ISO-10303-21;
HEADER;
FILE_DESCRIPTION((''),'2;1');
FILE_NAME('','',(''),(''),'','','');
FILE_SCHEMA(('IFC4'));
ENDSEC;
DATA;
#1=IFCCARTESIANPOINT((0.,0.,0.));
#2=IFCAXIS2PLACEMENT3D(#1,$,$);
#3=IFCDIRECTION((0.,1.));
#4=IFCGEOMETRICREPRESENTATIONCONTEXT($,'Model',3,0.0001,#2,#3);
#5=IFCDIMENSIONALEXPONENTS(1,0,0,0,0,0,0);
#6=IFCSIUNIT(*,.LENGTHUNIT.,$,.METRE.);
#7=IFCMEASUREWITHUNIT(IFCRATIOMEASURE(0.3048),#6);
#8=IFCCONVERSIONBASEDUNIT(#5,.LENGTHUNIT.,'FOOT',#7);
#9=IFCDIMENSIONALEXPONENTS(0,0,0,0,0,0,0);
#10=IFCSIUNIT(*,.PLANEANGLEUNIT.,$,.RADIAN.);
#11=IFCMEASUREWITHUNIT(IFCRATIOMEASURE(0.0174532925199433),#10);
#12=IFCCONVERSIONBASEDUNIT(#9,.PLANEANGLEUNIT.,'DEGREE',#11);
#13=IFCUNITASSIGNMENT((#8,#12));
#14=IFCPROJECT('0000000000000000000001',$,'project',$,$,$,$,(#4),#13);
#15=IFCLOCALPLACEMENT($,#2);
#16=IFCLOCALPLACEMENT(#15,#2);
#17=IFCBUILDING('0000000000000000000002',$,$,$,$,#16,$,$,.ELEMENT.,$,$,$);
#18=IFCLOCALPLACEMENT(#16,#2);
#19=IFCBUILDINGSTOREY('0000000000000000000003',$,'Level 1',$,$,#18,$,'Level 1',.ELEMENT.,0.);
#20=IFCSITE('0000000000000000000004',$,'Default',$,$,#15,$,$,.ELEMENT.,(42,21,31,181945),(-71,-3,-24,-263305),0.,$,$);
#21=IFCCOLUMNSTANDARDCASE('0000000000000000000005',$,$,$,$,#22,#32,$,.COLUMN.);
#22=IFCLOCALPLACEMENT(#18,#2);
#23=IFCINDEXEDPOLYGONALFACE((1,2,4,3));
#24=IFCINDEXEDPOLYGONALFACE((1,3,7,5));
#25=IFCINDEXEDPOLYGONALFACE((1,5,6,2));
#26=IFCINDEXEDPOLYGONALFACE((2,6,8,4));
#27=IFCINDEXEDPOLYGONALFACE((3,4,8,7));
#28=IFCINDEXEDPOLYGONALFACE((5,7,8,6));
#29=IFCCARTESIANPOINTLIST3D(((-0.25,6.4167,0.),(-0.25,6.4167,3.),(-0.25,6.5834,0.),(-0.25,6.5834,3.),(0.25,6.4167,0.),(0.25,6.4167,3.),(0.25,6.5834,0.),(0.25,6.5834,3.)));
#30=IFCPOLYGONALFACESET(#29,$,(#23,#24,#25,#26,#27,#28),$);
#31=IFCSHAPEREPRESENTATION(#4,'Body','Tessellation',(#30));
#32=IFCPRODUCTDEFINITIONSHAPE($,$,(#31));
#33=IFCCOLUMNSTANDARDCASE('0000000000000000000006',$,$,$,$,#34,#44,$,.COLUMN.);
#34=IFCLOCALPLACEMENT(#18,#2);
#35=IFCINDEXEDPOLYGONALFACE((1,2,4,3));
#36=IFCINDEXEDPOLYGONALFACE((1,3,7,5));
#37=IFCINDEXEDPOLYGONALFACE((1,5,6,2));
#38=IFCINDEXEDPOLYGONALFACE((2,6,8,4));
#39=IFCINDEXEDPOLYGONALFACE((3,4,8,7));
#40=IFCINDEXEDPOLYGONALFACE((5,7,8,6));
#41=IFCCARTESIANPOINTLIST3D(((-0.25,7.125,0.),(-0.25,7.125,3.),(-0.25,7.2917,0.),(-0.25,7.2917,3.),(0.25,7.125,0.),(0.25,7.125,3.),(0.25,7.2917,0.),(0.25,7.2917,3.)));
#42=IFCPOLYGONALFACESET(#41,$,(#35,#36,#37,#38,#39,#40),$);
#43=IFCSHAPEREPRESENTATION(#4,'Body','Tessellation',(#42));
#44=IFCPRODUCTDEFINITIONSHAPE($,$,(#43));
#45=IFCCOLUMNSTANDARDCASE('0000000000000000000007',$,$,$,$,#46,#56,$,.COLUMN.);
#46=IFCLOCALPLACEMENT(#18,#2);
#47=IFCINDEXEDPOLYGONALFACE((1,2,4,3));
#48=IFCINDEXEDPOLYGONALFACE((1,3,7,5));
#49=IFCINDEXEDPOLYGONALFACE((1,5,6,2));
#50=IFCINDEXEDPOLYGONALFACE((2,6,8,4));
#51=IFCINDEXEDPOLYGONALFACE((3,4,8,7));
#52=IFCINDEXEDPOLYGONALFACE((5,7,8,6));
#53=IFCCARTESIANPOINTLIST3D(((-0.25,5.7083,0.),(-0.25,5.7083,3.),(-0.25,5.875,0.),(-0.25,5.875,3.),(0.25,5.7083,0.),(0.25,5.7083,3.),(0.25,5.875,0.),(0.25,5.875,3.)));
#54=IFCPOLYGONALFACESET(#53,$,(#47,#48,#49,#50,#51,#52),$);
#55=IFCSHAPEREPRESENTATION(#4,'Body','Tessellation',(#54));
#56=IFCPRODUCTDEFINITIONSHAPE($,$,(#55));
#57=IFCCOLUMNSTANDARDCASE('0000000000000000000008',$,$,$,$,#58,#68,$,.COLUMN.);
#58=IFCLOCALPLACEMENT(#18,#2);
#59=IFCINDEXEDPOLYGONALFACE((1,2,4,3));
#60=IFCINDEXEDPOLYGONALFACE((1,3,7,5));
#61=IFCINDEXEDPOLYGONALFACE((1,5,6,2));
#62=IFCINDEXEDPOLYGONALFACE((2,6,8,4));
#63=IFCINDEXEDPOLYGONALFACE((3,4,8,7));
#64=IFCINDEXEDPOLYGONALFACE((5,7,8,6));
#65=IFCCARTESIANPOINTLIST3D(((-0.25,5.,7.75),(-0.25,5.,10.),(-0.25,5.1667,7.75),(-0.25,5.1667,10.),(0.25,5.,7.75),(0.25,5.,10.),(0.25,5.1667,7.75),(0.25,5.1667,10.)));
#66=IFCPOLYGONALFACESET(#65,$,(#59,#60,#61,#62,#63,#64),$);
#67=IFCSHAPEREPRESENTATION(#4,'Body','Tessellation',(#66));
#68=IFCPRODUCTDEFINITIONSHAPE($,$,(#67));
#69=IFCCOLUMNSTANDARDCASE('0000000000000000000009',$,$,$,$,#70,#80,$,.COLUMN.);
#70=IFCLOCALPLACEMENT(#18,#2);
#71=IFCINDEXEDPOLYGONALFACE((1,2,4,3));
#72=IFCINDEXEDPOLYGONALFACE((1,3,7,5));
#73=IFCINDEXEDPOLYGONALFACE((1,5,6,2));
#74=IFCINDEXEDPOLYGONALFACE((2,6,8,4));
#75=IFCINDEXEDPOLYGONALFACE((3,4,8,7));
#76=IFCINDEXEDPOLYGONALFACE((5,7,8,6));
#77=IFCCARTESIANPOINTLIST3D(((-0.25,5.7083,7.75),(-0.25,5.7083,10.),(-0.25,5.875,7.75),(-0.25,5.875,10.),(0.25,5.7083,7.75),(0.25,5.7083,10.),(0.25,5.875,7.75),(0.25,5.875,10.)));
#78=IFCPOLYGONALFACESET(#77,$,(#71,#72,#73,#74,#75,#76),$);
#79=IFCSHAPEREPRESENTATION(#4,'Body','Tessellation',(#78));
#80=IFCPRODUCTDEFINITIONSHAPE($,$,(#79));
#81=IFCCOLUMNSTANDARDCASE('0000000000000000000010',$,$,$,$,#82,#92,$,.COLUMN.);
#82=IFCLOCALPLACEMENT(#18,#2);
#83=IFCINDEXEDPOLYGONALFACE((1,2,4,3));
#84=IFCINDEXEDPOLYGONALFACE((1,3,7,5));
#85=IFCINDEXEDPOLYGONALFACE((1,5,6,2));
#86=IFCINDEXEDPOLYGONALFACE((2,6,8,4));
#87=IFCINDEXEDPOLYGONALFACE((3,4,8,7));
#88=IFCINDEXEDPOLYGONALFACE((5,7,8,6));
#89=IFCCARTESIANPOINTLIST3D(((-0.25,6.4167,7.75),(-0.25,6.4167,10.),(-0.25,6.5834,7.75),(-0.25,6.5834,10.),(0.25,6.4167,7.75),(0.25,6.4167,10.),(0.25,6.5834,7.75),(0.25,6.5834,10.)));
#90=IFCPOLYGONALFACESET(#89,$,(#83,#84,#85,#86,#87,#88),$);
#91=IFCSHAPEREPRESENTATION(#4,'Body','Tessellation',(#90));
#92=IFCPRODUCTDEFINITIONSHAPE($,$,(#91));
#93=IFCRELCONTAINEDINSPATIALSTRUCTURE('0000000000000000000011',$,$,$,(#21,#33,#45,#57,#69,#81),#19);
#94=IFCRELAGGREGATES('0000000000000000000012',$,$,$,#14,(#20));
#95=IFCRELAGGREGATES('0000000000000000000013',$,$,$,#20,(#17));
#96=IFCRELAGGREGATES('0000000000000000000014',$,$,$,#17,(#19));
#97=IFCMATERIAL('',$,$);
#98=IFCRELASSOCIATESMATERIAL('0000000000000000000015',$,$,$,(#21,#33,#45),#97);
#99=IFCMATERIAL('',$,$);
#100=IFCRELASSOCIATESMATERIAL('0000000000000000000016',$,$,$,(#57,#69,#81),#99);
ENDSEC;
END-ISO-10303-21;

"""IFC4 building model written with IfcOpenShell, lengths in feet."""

from ifc_helpers import new_model, entity, si_unit, converted_unit, direction, frame, origin, place, context, project, spatial, rectangle, extrude, material, element, save


model = new_model("IFC4")

# Units and contexts
model_context = context("Model", 3, precision=0.0001, world=origin(), true_north=direction((0.0, 1.0)))
ifc_project = project(units=[converted_unit("LENGTHUNIT", "FOOT", entity("IfcRatioMeasure", 0.3048), si_unit("LENGTHUNIT", "METRE"), dimensions=[1, 0, 0, 0, 0, 0, 0]), converted_unit("PLANEANGLEUNIT", "DEGREE", entity("IfcRatioMeasure", 0.0174532925199433), si_unit("PLANEANGLEUNIT", "RADIAN"), dimensions=[0, 0, 0, 0, 0, 0, 0])], contexts=[model_context])

# Site, building, storey
site_placement = place(None, origin())
site = spatial("IfcSite", under=ifc_project, at=site_placement, Name="Default", CompositionType="ELEMENT", RefLatitude=(42, 21, 31, 181945), RefLongitude=(-71, -3, -24, -263305), RefElevation=0.0)
building_placement = place(site_placement, origin())
building = spatial("IfcBuilding", under=site, at=building_placement, CompositionType="ELEMENT")
storey_placement = place(building_placement, origin())
storey = spatial("IfcBuildingStorey", under=building, at=storey_placement, Name="Level 1", LongName="Level 1", CompositionType="ELEMENT", Elevation=0.0)

# Columns
ifc_material_1 = material(Name="")
placement_1 = place(storey_placement, frame((0.0, -0.25, 0.0), z_axis=(0.0, 0.0, 1.0), x_axis=(0.0, 1.0, 0.0)))
for number, where, z_axis, x_axis in (
    (1, (6.75, 0.0, 0.0), (0.0, 0.0, 1.0), (1.0, 0.0, 0.0)),
    (2, (7.4583, 0.0, 0.0), (0.0, 0.0, 1.0), (1.0, 0.0, 0.0)),
    (3, (6.0417, 0.0, 0.0), (0.0, 0.0, 1.0), (1.0, 0.0, 0.0)),
):
    element("IfcColumnStandardCase", number, at=place(placement_1, frame(where, z_axis=z_axis, x_axis=x_axis)), inside=storey, material=ifc_material_1, PredefinedType="COLUMN", context=model_context, shape_type="SweptSolid", body=[
        extrude(rectangle(XDim=0.1667, YDim=0.5), origin(), (0.0, 0.0, 1.0), 3.0),
    ])
ifc_material_2 = material(Name="")
for number, where, z_axis, x_axis in (
    (4, (5.3334, 0.0, 7.75), (0.0, 0.0, 1.0), (1.0, 0.0, 0.0)),
    (5, (6.0417, 0.0, 7.75), (0.0, 0.0, 1.0), (1.0, 0.0, 0.0)),
    (6, (6.75, 0.0, 7.75), (0.0, 0.0, 1.0), (1.0, 0.0, 0.0)),
):
    element("IfcColumnStandardCase", number, at=place(placement_1, frame(where, z_axis=z_axis, x_axis=x_axis)), inside=storey, material=ifc_material_2, PredefinedType="COLUMN", context=model_context, shape_type="SweptSolid", body=[
        extrude(rectangle(XDim=0.1667, YDim=0.5), origin(), (0.0, 0.0, 1.0), 2.25),
    ])

save(model, "model.ifc")
